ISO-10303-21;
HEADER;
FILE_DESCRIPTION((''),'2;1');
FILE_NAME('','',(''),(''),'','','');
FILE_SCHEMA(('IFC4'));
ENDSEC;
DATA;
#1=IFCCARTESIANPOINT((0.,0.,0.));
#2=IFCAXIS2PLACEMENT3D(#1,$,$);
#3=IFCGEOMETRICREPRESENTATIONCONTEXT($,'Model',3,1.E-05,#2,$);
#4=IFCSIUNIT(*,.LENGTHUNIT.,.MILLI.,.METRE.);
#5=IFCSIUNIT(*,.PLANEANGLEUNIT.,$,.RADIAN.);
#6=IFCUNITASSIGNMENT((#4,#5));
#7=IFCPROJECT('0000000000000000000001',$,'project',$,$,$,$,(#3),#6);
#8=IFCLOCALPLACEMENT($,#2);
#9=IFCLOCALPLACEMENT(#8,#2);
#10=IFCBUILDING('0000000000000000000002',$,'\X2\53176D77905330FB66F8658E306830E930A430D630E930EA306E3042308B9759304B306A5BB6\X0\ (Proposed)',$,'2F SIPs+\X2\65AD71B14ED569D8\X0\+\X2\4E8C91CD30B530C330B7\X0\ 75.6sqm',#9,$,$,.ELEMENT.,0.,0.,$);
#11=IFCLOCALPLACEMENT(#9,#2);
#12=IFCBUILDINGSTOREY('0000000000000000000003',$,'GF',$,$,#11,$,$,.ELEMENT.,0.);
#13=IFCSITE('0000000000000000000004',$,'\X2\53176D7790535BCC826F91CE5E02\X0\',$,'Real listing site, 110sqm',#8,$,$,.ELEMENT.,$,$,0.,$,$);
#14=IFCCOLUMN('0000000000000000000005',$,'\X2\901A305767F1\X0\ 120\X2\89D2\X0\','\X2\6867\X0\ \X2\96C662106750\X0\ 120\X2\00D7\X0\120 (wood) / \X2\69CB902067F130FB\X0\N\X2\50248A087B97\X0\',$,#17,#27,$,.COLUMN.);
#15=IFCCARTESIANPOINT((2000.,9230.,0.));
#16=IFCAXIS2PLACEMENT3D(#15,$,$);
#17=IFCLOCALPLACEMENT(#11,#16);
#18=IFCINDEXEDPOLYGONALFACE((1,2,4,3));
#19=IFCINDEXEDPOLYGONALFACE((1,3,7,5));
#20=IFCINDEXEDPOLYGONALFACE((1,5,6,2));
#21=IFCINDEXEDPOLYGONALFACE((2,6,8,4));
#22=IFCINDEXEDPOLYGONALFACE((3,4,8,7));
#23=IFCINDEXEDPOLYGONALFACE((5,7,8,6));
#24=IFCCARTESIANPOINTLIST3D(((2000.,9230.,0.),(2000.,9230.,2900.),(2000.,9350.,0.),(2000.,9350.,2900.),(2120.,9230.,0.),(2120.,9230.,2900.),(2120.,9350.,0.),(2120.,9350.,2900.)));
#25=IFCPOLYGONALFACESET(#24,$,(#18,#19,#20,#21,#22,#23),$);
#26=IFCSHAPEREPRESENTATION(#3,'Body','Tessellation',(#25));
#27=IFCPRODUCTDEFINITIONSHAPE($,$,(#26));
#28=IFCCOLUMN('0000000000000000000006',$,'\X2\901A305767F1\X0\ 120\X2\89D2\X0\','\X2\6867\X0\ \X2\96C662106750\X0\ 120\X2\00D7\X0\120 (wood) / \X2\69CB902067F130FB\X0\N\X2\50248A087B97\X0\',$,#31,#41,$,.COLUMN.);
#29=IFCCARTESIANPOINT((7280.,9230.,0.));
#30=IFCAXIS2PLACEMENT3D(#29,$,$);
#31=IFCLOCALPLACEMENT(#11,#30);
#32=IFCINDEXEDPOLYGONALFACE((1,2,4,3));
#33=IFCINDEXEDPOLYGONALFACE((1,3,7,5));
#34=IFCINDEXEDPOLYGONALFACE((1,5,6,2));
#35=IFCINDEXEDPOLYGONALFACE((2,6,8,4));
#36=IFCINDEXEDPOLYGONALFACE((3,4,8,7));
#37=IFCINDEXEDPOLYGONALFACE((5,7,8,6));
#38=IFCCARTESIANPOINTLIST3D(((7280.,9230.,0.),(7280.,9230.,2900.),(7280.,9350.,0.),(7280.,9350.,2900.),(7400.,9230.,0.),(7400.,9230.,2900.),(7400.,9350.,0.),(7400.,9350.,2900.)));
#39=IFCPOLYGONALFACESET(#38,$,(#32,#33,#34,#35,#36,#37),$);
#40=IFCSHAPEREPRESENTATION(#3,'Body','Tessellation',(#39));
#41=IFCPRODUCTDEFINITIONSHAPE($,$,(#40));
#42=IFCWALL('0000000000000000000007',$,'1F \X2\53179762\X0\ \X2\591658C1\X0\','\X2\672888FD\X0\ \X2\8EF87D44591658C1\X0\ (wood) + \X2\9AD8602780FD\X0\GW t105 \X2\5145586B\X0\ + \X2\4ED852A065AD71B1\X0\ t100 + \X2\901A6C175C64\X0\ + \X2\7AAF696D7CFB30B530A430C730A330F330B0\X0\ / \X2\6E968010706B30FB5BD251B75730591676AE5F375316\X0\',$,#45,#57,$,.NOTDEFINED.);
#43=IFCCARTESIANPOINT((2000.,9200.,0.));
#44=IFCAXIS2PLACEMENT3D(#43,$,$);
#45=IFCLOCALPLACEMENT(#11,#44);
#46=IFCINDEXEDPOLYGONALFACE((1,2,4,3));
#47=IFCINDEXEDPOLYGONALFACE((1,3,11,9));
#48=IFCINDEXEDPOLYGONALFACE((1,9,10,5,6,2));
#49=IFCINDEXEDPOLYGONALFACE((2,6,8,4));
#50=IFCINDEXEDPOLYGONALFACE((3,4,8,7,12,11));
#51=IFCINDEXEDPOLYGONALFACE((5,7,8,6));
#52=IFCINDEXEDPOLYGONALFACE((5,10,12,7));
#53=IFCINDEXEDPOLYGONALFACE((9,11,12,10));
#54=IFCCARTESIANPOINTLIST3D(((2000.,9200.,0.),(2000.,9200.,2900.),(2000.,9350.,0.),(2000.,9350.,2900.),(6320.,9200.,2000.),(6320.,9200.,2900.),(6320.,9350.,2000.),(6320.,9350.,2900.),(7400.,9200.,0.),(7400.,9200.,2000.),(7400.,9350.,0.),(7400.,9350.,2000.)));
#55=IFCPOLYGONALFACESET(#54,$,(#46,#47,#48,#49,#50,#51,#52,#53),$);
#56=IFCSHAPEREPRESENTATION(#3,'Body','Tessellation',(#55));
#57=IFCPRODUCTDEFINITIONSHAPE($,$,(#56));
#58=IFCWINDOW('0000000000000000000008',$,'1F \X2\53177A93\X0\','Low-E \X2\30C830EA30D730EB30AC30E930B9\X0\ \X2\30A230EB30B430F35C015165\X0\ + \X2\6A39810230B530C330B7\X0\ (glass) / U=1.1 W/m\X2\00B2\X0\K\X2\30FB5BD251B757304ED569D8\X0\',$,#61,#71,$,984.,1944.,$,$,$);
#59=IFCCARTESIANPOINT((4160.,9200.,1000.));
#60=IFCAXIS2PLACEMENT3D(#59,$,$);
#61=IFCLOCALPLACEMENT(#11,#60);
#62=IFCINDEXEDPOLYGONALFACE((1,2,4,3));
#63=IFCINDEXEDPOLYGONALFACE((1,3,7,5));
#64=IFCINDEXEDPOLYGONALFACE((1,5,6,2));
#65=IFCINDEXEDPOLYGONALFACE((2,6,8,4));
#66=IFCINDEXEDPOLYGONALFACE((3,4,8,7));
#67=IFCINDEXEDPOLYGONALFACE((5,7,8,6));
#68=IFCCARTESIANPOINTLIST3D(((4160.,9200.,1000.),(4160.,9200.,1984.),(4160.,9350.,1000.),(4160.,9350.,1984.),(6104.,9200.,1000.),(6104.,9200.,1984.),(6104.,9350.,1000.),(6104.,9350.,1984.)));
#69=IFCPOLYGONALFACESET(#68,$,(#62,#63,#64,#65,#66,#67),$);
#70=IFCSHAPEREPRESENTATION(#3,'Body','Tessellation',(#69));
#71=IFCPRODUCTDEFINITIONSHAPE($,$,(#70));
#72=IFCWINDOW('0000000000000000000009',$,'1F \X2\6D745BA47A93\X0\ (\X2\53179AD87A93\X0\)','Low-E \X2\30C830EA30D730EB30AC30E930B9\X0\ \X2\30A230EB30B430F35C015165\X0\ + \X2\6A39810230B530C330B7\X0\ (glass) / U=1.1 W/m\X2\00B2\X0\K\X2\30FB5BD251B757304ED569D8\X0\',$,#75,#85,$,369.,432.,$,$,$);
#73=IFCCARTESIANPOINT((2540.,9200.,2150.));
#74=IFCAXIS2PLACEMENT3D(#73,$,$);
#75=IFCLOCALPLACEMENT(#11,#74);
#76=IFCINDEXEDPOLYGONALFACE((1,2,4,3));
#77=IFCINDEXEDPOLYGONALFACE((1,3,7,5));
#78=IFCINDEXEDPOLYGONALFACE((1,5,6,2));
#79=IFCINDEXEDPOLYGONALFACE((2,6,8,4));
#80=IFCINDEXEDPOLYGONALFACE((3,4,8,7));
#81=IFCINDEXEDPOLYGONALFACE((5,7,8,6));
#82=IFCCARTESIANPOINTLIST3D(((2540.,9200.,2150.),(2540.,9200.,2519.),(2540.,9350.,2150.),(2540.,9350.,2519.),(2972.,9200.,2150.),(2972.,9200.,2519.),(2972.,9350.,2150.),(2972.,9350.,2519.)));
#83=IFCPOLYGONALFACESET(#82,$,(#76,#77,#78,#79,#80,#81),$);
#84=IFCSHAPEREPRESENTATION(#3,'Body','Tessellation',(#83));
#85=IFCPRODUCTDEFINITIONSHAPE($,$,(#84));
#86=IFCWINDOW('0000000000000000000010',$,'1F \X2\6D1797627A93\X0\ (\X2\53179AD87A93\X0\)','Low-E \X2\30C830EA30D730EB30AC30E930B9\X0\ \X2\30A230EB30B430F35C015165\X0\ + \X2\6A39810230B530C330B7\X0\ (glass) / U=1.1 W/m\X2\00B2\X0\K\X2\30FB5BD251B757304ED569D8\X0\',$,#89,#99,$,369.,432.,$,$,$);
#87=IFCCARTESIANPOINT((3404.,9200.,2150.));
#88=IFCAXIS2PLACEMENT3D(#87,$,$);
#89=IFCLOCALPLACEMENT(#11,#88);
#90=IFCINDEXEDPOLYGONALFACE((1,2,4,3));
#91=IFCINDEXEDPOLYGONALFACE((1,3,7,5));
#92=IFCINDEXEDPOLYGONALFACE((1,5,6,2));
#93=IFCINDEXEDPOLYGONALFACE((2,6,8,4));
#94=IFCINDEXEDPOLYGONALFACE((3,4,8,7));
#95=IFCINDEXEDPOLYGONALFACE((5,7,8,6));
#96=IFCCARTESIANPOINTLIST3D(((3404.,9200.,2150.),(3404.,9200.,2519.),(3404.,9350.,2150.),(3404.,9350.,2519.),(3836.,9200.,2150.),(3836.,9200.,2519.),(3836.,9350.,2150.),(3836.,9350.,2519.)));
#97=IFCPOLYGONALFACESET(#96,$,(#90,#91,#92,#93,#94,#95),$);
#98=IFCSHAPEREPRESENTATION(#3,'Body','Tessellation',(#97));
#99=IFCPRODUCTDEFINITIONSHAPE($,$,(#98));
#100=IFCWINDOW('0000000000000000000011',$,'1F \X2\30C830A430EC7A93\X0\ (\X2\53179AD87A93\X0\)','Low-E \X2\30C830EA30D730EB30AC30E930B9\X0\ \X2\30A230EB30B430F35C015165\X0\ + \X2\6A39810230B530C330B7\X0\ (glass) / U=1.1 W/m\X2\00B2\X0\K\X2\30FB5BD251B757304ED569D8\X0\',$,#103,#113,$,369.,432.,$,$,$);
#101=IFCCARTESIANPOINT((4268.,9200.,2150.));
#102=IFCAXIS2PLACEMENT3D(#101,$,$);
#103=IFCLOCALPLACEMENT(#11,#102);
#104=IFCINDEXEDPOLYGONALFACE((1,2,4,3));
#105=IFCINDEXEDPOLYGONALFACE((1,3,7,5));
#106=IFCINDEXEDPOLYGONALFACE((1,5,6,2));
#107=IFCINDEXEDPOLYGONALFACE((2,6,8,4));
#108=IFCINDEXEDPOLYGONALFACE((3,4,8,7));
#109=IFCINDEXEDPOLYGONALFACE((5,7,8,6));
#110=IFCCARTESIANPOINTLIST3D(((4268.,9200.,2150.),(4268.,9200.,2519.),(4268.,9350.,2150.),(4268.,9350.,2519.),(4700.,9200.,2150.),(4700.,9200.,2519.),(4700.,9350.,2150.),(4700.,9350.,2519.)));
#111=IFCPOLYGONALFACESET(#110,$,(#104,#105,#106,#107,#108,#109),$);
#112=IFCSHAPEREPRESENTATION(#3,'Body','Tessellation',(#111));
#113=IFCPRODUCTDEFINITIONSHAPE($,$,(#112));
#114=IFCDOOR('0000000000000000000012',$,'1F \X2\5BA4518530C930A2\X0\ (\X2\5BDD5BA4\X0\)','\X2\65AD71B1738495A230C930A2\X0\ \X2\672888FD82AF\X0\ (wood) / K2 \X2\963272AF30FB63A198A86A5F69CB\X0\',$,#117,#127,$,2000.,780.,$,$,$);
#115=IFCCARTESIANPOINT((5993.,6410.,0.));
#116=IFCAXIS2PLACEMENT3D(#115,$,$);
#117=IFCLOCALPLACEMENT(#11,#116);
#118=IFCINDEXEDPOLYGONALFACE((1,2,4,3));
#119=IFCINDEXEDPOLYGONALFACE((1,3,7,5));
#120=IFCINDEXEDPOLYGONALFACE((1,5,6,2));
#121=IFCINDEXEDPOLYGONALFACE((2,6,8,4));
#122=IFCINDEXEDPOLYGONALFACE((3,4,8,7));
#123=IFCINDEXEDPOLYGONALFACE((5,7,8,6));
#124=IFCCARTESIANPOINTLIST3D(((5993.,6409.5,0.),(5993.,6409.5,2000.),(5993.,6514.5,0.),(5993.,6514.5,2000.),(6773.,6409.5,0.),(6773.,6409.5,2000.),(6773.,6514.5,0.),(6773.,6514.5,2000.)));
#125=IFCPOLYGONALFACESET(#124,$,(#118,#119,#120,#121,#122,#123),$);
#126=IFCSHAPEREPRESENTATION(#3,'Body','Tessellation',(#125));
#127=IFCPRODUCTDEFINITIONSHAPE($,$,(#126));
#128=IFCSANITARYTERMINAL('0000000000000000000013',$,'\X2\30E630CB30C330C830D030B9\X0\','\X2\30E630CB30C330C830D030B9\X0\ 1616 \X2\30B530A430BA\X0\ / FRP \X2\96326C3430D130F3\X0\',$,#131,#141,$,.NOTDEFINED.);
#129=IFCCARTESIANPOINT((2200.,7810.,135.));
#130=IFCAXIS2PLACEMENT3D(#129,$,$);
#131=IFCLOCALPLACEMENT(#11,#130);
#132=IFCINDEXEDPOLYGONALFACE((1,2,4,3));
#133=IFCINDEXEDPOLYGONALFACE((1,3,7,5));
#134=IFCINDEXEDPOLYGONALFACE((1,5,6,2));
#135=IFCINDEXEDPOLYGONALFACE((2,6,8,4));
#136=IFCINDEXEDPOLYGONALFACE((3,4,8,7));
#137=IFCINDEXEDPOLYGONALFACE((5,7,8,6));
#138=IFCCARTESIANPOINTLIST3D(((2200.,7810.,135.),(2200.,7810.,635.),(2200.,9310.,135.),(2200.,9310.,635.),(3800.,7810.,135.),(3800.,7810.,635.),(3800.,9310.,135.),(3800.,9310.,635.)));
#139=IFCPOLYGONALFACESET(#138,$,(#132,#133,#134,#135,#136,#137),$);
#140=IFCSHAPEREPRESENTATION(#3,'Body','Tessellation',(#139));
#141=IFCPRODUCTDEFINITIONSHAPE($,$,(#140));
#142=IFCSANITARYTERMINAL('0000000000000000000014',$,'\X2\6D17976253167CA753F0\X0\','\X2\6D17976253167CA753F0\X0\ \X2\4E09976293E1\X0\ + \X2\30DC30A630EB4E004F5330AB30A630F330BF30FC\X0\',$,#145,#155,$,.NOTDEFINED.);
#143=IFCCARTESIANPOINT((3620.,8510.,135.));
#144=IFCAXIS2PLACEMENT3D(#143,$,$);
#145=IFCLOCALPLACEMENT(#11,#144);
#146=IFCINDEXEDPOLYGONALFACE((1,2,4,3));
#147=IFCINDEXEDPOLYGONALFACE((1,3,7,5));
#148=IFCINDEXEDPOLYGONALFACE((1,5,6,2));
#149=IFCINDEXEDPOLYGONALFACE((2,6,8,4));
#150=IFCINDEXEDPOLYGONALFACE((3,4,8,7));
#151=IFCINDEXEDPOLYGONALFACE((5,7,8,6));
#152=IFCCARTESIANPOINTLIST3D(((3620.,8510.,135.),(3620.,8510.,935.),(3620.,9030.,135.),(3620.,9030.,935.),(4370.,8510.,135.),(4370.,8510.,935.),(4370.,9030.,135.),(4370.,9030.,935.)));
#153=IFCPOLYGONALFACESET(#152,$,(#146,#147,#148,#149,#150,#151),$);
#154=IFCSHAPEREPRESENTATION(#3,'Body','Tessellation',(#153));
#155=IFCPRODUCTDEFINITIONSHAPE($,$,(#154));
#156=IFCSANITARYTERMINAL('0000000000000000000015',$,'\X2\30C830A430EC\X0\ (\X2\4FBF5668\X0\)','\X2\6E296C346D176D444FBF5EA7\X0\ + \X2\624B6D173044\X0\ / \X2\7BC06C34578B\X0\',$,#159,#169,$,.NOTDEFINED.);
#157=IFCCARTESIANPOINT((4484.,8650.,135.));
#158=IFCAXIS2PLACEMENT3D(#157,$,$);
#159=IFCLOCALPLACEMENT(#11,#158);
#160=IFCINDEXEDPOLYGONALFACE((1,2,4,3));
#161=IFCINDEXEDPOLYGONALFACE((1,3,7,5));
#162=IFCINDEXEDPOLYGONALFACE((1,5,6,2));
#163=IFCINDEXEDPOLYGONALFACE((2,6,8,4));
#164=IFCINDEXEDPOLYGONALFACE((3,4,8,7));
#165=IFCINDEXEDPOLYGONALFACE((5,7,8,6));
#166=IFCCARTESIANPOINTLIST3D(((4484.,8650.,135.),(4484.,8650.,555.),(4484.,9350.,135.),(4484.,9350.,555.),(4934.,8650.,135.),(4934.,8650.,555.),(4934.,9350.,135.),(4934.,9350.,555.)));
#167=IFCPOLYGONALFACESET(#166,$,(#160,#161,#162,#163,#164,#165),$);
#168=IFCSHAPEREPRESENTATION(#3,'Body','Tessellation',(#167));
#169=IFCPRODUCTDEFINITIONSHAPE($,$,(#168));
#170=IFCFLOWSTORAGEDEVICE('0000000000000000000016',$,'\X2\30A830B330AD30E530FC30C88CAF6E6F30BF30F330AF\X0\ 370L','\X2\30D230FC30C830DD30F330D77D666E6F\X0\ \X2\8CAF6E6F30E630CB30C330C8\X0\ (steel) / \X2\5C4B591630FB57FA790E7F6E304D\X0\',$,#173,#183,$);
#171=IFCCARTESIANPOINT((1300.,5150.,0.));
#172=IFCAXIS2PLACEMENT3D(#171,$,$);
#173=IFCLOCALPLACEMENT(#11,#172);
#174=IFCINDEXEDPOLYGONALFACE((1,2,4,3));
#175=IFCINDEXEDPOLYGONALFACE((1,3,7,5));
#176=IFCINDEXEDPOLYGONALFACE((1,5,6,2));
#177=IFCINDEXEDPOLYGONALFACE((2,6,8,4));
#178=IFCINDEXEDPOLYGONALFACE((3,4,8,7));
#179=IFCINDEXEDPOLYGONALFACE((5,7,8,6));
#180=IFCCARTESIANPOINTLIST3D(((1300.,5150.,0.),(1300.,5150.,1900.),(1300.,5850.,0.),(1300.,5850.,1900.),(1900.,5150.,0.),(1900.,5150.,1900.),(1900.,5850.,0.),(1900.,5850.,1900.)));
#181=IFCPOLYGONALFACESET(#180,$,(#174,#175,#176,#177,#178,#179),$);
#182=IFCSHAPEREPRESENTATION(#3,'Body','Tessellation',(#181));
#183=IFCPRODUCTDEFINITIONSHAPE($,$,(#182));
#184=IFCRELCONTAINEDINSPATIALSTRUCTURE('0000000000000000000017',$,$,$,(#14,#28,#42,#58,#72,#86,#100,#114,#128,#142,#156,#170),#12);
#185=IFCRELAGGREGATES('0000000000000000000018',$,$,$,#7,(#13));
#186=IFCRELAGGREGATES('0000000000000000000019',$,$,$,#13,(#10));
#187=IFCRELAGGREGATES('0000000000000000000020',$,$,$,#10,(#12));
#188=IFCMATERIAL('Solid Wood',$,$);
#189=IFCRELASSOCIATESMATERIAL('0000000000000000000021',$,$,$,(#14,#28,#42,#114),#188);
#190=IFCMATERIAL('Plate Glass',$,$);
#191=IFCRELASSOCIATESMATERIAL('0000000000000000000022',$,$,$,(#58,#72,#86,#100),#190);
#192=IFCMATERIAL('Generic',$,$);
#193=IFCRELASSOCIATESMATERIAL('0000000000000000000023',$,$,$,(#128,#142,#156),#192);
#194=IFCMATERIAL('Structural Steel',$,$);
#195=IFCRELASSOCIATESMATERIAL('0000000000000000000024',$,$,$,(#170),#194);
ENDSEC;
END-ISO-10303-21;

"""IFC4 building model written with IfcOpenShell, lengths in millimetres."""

from ifc_helpers import new_model, si_unit, frame, frame_2d, origin, place, context, project, spatial, rectangle, extrude, material, element, fill, save


model = new_model("IFC4")

# Units and contexts
model_context = context("Model", 3, precision=1e-05, world=origin())
ifc_project = project(units=[si_unit("LENGTHUNIT", "METRE", prefix="MILLI"), si_unit("PLANEANGLEUNIT", "RADIAN")], contexts=[model_context])

# Site, building, storey
site_placement = place(None, origin())
site = spatial("IfcSite", under=ifc_project, at=site_placement, Name="北海道富良野市", ObjectType="Real listing site, 110sqm", CompositionType="ELEMENT", RefElevation=0.0)
building_placement = place(site_placement, origin())
building = spatial("IfcBuilding", under=site, at=building_placement, Name="北海道・書斎とライブラリのある静かな家 (Proposed)", ObjectType="2F SIPs+断熱仕様+二重サッシ 75.6sqm", CompositionType="ELEMENT", ElevationOfRefHeight=0.0, ElevationOfTerrain=0.0)
storey_placement = place(building_placement, origin())
storey = spatial("IfcBuildingStorey", under=building, at=storey_placement, Name="GF", CompositionType="ELEMENT", Elevation=0.0)

# Columns
ifc_material_1 = material(Name="Solid Wood")
column_1_placement = place(storey_placement, frame((2000.0, 9230.0, 0.0)))
element("IfcColumn", 1, at=column_1_placement, inside=storey, material=ifc_material_1, Name="通し柱 120角", Description="桧 集成材 120×120 (wood) / 構造柱・N値計算", PredefinedType="COLUMN", context=model_context, shape_type="SweptSolid", body=[
    extrude(rectangle(XDim=120.0, YDim=120.0, at=frame_2d((60.0, 60.0))), frame((2000.0, 9230.0, 0.0)), (0.0, 0.0, 1.0), 2900.0),
])
column_2_placement = place(storey_placement, frame((7280.0, 9230.0, 0.0)))
element("IfcColumn", 2, at=column_2_placement, inside=storey, material=ifc_material_1, Name="通し柱 120角", Description="桧 集成材 120×120 (wood) / 構造柱・N値計算", PredefinedType="COLUMN", context=model_context, shape_type="SweptSolid", body=[
    extrude(rectangle(XDim=120.0, YDim=120.0, at=frame_2d((60.0, 60.0))), frame((7280.0, 9230.0, 0.0)), (0.0, 0.0, 1.0), 2900.0),
])

# Wall, openings, windows
wall_1_placement = place(storey_placement, frame((2000.0, 9200.0, 0.0)))
wall_1 = element("IfcWall", 3, at=wall_1_placement, inside=storey, material=ifc_material_1, Name="1F 北面 外壁", Description="木製 軸組外壁 (wood) + 高性能GW t105 充填 + 付加断熱 t100 + 通気層 + 窯業系サイディング / 準耐火・寒冷地外皮強化", PredefinedType="NOTDEFINED", context=model_context, shape_type="SweptSolid", body=[
    extrude(rectangle(XDim=5400.0, YDim=150.0, at=frame_2d((2700.0, 75.0))), frame((2000.0, 9200.0, 0.0)), (0.0, 0.0, 1.0), 2900.0),
])
opening_1_placement = place(storey_placement, frame((4160.0, 9200.0, 1000.0)))
opening_1 = element("IfcOpeningElement", 4, at=opening_1_placement, cuts=wall_1, PredefinedType="NOTDEFINED", context=model_context, shape_type="SweptSolid", body=[
    extrude(rectangle(XDim=1944.0, YDim=150.0, at=frame_2d((972.0, 75.0))), frame((4160.0, 9200.0, 1000.0)), (0.0, 0.0, 1.0), 984.0),
])
opening_2_placement = place(storey_placement, frame((2540.0, 9200.0, 2150.0)))
opening_2 = element("IfcOpeningElement", 5, at=opening_2_placement, cuts=wall_1, PredefinedType="NOTDEFINED", context=model_context, shape_type="SweptSolid", body=[
    extrude(rectangle(XDim=432.0, YDim=150.0, at=frame_2d((216.0, 75.0))), frame((2540.0, 9200.0, 2150.0)), (0.0, 0.0, 1.0), 369.0),
])
opening_3_placement = place(storey_placement, frame((3404.0, 9200.0, 2150.0)))
opening_3 = element("IfcOpeningElement", 6, at=opening_3_placement, cuts=wall_1, PredefinedType="NOTDEFINED", context=model_context, shape_type="SweptSolid", body=[
    extrude(rectangle(XDim=432.0, YDim=150.0, at=frame_2d((216.0, 75.0))), frame((3404.0, 9200.0, 2150.0)), (0.0, 0.0, 1.0), 369.0),
])
opening_4_placement = place(storey_placement, frame((4268.0, 9200.0, 2150.0)))
opening_4 = element("IfcOpeningElement", 7, at=opening_4_placement, cuts=wall_1, PredefinedType="NOTDEFINED", context=model_context, shape_type="SweptSolid", body=[
    extrude(rectangle(XDim=432.0, YDim=150.0, at=frame_2d((216.0, 75.0))), frame((4268.0, 9200.0, 2150.0)), (0.0, 0.0, 1.0), 369.0),
])
ifc_material_2 = material(Name="Plate Glass")
window_1_placement = place(storey_placement, frame((4160.0, 9200.0, 1000.0)))
window_1 = element("IfcWindow", 8, at=window_1_placement, inside=storey, material=ifc_material_2, Name="1F 北窓", Description="Low-E トリプルガラス アルゴン封入 + 樹脂サッシ (glass) / U=1.1 W/m²K・寒冷地仕様", OverallHeight=984.0, OverallWidth=1944.0, context=model_context, shape_type="SweptSolid", body=[
    extrude(rectangle(XDim=1944.0, YDim=150.0, at=frame_2d((972.0, 75.0))), frame((4160.0, 9200.0, 1000.0)), (0.0, 0.0, 1.0), 984.0),
])
fill(opening_1, window_1)
window_2_placement = place(storey_placement, frame((2540.0, 9200.0, 2150.0)))
window_2 = element("IfcWindow", 9, at=window_2_placement, inside=storey, material=ifc_material_2, Name="1F 浴室窓 (北高窓)", Description="Low-E トリプルガラス アルゴン封入 + 樹脂サッシ (glass) / U=1.1 W/m²K・寒冷地仕様", OverallHeight=369.0, OverallWidth=432.0, context=model_context, shape_type="SweptSolid", body=[
    extrude(rectangle(XDim=432.0, YDim=150.0, at=frame_2d((216.0, 75.0))), frame((2540.0, 9200.0, 2150.0)), (0.0, 0.0, 1.0), 369.0),
])
fill(opening_2, window_2)
window_3_placement = place(storey_placement, frame((3404.0, 9200.0, 2150.0)))
window_3 = element("IfcWindow", 10, at=window_3_placement, inside=storey, material=ifc_material_2, Name="1F 洗面窓 (北高窓)", Description="Low-E トリプルガラス アルゴン封入 + 樹脂サッシ (glass) / U=1.1 W/m²K・寒冷地仕様", OverallHeight=369.0, OverallWidth=432.0, context=model_context, shape_type="SweptSolid", body=[
    extrude(rectangle(XDim=432.0, YDim=150.0, at=frame_2d((216.0, 75.0))), frame((3404.0, 9200.0, 2150.0)), (0.0, 0.0, 1.0), 369.0),
])
fill(opening_3, window_3)
window_4_placement = place(storey_placement, frame((4268.0, 9200.0, 2150.0)))
window_4 = element("IfcWindow", 11, at=window_4_placement, inside=storey, material=ifc_material_2, Name="1F トイレ窓 (北高窓)", Description="Low-E トリプルガラス アルゴン封入 + 樹脂サッシ (glass) / U=1.1 W/m²K・寒冷地仕様", OverallHeight=369.0, OverallWidth=432.0, context=model_context, shape_type="SweptSolid", body=[
    extrude(rectangle(XDim=432.0, YDim=150.0, at=frame_2d((216.0, 75.0))), frame((4268.0, 9200.0, 2150.0)), (0.0, 0.0, 1.0), 369.0),
])
fill(opening_4, window_4)

# Door
door_1_placement = place(storey_placement, frame((5993.0, 6410.0, 0.0)))
element("IfcDoor", 12, at=door_1_placement, inside=storey, material=ifc_material_1, Name="1F 室内ドア (寝室)", Description="断熱玄関ドア 木製芯 (wood) / K2 防犯・採風機構", OverallHeight=2000.0, OverallWidth=780.0, context=model_context, shape_type="SweptSolid", body=[
    extrude(rectangle(XDim=780.0, YDim=105.0, at=frame_2d((390.0, 52.0))), frame((5993.0, 6410.0, 0.0)), (0.0, 0.0, 1.0), 2000.0),
])

# Sanitary terminals
ifc_material_3 = material(Name="Generic")
sanitary_terminal_1_placement = place(storey_placement, frame((2200.0, 7810.0, 135.0)))
element("IfcSanitaryTerminal", 13, at=sanitary_terminal_1_placement, inside=storey, material=ifc_material_3, Name="ユニットバス", Description="ユニットバス 1616 サイズ / FRP 防水パン", PredefinedType="NOTDEFINED", context=model_context, shape_type="SweptSolid", body=[
    extrude(rectangle(XDim=1600.0, YDim=1500.0, at=frame_2d((800.0, 750.0))), frame((2200.0, 7810.0, 135.0)), (0.0, 0.0, 1.0), 500.0),
])
sanitary_terminal_2_placement = place(storey_placement, frame((3620.0, 8510.0, 135.0)))
element("IfcSanitaryTerminal", 14, at=sanitary_terminal_2_placement, inside=storey, material=ifc_material_3, Name="洗面化粧台", Description="洗面化粧台 三面鏡 + ボウル一体カウンター", PredefinedType="NOTDEFINED", context=model_context, shape_type="SweptSolid", body=[
    extrude(rectangle(XDim=750.0, YDim=520.0, at=frame_2d((375.0, 260.0))), frame((3620.0, 8510.0, 135.0)), (0.0, 0.0, 1.0), 800.0),
])
sanitary_terminal_3_placement = place(storey_placement, frame((4484.0, 8650.0, 135.0)))
element("IfcSanitaryTerminal", 15, at=sanitary_terminal_3_placement, inside=storey, material=ifc_material_3, Name="トイレ (便器)", Description="温水洗浄便座 + 手洗い / 節水型", PredefinedType="NOTDEFINED", context=model_context, shape_type="SweptSolid", body=[
    extrude(rectangle(XDim=450.0, YDim=700.0, at=frame_2d((225.0, 350.0))), frame((4484.0, 8650.0, 135.0)), (0.0, 0.0, 1.0), 420.0),
])

# Flow storage device
ifc_material_4 = material(Name="Structural Steel")
flow_storage_device_placement = place(storey_placement, frame((1300.0, 5150.0, 0.0)))
element("IfcFlowStorageDevice", 16, at=flow_storage_device_placement, inside=storey, material=ifc_material_4, Name="エコキュート貯湯タンク 370L", Description="ヒートポンプ給湯 貯湯ユニット (steel) / 屋外・基礎置き", context=model_context, shape_type="SweptSolid", body=[
    extrude(rectangle(XDim=600.0, YDim=700.0, at=frame_2d((300.0, 350.0))), frame((1300.0, 5150.0, 0.0)), (0.0, 0.0, 1.0), 1900.0),
])

save(model, "model.ifc")
